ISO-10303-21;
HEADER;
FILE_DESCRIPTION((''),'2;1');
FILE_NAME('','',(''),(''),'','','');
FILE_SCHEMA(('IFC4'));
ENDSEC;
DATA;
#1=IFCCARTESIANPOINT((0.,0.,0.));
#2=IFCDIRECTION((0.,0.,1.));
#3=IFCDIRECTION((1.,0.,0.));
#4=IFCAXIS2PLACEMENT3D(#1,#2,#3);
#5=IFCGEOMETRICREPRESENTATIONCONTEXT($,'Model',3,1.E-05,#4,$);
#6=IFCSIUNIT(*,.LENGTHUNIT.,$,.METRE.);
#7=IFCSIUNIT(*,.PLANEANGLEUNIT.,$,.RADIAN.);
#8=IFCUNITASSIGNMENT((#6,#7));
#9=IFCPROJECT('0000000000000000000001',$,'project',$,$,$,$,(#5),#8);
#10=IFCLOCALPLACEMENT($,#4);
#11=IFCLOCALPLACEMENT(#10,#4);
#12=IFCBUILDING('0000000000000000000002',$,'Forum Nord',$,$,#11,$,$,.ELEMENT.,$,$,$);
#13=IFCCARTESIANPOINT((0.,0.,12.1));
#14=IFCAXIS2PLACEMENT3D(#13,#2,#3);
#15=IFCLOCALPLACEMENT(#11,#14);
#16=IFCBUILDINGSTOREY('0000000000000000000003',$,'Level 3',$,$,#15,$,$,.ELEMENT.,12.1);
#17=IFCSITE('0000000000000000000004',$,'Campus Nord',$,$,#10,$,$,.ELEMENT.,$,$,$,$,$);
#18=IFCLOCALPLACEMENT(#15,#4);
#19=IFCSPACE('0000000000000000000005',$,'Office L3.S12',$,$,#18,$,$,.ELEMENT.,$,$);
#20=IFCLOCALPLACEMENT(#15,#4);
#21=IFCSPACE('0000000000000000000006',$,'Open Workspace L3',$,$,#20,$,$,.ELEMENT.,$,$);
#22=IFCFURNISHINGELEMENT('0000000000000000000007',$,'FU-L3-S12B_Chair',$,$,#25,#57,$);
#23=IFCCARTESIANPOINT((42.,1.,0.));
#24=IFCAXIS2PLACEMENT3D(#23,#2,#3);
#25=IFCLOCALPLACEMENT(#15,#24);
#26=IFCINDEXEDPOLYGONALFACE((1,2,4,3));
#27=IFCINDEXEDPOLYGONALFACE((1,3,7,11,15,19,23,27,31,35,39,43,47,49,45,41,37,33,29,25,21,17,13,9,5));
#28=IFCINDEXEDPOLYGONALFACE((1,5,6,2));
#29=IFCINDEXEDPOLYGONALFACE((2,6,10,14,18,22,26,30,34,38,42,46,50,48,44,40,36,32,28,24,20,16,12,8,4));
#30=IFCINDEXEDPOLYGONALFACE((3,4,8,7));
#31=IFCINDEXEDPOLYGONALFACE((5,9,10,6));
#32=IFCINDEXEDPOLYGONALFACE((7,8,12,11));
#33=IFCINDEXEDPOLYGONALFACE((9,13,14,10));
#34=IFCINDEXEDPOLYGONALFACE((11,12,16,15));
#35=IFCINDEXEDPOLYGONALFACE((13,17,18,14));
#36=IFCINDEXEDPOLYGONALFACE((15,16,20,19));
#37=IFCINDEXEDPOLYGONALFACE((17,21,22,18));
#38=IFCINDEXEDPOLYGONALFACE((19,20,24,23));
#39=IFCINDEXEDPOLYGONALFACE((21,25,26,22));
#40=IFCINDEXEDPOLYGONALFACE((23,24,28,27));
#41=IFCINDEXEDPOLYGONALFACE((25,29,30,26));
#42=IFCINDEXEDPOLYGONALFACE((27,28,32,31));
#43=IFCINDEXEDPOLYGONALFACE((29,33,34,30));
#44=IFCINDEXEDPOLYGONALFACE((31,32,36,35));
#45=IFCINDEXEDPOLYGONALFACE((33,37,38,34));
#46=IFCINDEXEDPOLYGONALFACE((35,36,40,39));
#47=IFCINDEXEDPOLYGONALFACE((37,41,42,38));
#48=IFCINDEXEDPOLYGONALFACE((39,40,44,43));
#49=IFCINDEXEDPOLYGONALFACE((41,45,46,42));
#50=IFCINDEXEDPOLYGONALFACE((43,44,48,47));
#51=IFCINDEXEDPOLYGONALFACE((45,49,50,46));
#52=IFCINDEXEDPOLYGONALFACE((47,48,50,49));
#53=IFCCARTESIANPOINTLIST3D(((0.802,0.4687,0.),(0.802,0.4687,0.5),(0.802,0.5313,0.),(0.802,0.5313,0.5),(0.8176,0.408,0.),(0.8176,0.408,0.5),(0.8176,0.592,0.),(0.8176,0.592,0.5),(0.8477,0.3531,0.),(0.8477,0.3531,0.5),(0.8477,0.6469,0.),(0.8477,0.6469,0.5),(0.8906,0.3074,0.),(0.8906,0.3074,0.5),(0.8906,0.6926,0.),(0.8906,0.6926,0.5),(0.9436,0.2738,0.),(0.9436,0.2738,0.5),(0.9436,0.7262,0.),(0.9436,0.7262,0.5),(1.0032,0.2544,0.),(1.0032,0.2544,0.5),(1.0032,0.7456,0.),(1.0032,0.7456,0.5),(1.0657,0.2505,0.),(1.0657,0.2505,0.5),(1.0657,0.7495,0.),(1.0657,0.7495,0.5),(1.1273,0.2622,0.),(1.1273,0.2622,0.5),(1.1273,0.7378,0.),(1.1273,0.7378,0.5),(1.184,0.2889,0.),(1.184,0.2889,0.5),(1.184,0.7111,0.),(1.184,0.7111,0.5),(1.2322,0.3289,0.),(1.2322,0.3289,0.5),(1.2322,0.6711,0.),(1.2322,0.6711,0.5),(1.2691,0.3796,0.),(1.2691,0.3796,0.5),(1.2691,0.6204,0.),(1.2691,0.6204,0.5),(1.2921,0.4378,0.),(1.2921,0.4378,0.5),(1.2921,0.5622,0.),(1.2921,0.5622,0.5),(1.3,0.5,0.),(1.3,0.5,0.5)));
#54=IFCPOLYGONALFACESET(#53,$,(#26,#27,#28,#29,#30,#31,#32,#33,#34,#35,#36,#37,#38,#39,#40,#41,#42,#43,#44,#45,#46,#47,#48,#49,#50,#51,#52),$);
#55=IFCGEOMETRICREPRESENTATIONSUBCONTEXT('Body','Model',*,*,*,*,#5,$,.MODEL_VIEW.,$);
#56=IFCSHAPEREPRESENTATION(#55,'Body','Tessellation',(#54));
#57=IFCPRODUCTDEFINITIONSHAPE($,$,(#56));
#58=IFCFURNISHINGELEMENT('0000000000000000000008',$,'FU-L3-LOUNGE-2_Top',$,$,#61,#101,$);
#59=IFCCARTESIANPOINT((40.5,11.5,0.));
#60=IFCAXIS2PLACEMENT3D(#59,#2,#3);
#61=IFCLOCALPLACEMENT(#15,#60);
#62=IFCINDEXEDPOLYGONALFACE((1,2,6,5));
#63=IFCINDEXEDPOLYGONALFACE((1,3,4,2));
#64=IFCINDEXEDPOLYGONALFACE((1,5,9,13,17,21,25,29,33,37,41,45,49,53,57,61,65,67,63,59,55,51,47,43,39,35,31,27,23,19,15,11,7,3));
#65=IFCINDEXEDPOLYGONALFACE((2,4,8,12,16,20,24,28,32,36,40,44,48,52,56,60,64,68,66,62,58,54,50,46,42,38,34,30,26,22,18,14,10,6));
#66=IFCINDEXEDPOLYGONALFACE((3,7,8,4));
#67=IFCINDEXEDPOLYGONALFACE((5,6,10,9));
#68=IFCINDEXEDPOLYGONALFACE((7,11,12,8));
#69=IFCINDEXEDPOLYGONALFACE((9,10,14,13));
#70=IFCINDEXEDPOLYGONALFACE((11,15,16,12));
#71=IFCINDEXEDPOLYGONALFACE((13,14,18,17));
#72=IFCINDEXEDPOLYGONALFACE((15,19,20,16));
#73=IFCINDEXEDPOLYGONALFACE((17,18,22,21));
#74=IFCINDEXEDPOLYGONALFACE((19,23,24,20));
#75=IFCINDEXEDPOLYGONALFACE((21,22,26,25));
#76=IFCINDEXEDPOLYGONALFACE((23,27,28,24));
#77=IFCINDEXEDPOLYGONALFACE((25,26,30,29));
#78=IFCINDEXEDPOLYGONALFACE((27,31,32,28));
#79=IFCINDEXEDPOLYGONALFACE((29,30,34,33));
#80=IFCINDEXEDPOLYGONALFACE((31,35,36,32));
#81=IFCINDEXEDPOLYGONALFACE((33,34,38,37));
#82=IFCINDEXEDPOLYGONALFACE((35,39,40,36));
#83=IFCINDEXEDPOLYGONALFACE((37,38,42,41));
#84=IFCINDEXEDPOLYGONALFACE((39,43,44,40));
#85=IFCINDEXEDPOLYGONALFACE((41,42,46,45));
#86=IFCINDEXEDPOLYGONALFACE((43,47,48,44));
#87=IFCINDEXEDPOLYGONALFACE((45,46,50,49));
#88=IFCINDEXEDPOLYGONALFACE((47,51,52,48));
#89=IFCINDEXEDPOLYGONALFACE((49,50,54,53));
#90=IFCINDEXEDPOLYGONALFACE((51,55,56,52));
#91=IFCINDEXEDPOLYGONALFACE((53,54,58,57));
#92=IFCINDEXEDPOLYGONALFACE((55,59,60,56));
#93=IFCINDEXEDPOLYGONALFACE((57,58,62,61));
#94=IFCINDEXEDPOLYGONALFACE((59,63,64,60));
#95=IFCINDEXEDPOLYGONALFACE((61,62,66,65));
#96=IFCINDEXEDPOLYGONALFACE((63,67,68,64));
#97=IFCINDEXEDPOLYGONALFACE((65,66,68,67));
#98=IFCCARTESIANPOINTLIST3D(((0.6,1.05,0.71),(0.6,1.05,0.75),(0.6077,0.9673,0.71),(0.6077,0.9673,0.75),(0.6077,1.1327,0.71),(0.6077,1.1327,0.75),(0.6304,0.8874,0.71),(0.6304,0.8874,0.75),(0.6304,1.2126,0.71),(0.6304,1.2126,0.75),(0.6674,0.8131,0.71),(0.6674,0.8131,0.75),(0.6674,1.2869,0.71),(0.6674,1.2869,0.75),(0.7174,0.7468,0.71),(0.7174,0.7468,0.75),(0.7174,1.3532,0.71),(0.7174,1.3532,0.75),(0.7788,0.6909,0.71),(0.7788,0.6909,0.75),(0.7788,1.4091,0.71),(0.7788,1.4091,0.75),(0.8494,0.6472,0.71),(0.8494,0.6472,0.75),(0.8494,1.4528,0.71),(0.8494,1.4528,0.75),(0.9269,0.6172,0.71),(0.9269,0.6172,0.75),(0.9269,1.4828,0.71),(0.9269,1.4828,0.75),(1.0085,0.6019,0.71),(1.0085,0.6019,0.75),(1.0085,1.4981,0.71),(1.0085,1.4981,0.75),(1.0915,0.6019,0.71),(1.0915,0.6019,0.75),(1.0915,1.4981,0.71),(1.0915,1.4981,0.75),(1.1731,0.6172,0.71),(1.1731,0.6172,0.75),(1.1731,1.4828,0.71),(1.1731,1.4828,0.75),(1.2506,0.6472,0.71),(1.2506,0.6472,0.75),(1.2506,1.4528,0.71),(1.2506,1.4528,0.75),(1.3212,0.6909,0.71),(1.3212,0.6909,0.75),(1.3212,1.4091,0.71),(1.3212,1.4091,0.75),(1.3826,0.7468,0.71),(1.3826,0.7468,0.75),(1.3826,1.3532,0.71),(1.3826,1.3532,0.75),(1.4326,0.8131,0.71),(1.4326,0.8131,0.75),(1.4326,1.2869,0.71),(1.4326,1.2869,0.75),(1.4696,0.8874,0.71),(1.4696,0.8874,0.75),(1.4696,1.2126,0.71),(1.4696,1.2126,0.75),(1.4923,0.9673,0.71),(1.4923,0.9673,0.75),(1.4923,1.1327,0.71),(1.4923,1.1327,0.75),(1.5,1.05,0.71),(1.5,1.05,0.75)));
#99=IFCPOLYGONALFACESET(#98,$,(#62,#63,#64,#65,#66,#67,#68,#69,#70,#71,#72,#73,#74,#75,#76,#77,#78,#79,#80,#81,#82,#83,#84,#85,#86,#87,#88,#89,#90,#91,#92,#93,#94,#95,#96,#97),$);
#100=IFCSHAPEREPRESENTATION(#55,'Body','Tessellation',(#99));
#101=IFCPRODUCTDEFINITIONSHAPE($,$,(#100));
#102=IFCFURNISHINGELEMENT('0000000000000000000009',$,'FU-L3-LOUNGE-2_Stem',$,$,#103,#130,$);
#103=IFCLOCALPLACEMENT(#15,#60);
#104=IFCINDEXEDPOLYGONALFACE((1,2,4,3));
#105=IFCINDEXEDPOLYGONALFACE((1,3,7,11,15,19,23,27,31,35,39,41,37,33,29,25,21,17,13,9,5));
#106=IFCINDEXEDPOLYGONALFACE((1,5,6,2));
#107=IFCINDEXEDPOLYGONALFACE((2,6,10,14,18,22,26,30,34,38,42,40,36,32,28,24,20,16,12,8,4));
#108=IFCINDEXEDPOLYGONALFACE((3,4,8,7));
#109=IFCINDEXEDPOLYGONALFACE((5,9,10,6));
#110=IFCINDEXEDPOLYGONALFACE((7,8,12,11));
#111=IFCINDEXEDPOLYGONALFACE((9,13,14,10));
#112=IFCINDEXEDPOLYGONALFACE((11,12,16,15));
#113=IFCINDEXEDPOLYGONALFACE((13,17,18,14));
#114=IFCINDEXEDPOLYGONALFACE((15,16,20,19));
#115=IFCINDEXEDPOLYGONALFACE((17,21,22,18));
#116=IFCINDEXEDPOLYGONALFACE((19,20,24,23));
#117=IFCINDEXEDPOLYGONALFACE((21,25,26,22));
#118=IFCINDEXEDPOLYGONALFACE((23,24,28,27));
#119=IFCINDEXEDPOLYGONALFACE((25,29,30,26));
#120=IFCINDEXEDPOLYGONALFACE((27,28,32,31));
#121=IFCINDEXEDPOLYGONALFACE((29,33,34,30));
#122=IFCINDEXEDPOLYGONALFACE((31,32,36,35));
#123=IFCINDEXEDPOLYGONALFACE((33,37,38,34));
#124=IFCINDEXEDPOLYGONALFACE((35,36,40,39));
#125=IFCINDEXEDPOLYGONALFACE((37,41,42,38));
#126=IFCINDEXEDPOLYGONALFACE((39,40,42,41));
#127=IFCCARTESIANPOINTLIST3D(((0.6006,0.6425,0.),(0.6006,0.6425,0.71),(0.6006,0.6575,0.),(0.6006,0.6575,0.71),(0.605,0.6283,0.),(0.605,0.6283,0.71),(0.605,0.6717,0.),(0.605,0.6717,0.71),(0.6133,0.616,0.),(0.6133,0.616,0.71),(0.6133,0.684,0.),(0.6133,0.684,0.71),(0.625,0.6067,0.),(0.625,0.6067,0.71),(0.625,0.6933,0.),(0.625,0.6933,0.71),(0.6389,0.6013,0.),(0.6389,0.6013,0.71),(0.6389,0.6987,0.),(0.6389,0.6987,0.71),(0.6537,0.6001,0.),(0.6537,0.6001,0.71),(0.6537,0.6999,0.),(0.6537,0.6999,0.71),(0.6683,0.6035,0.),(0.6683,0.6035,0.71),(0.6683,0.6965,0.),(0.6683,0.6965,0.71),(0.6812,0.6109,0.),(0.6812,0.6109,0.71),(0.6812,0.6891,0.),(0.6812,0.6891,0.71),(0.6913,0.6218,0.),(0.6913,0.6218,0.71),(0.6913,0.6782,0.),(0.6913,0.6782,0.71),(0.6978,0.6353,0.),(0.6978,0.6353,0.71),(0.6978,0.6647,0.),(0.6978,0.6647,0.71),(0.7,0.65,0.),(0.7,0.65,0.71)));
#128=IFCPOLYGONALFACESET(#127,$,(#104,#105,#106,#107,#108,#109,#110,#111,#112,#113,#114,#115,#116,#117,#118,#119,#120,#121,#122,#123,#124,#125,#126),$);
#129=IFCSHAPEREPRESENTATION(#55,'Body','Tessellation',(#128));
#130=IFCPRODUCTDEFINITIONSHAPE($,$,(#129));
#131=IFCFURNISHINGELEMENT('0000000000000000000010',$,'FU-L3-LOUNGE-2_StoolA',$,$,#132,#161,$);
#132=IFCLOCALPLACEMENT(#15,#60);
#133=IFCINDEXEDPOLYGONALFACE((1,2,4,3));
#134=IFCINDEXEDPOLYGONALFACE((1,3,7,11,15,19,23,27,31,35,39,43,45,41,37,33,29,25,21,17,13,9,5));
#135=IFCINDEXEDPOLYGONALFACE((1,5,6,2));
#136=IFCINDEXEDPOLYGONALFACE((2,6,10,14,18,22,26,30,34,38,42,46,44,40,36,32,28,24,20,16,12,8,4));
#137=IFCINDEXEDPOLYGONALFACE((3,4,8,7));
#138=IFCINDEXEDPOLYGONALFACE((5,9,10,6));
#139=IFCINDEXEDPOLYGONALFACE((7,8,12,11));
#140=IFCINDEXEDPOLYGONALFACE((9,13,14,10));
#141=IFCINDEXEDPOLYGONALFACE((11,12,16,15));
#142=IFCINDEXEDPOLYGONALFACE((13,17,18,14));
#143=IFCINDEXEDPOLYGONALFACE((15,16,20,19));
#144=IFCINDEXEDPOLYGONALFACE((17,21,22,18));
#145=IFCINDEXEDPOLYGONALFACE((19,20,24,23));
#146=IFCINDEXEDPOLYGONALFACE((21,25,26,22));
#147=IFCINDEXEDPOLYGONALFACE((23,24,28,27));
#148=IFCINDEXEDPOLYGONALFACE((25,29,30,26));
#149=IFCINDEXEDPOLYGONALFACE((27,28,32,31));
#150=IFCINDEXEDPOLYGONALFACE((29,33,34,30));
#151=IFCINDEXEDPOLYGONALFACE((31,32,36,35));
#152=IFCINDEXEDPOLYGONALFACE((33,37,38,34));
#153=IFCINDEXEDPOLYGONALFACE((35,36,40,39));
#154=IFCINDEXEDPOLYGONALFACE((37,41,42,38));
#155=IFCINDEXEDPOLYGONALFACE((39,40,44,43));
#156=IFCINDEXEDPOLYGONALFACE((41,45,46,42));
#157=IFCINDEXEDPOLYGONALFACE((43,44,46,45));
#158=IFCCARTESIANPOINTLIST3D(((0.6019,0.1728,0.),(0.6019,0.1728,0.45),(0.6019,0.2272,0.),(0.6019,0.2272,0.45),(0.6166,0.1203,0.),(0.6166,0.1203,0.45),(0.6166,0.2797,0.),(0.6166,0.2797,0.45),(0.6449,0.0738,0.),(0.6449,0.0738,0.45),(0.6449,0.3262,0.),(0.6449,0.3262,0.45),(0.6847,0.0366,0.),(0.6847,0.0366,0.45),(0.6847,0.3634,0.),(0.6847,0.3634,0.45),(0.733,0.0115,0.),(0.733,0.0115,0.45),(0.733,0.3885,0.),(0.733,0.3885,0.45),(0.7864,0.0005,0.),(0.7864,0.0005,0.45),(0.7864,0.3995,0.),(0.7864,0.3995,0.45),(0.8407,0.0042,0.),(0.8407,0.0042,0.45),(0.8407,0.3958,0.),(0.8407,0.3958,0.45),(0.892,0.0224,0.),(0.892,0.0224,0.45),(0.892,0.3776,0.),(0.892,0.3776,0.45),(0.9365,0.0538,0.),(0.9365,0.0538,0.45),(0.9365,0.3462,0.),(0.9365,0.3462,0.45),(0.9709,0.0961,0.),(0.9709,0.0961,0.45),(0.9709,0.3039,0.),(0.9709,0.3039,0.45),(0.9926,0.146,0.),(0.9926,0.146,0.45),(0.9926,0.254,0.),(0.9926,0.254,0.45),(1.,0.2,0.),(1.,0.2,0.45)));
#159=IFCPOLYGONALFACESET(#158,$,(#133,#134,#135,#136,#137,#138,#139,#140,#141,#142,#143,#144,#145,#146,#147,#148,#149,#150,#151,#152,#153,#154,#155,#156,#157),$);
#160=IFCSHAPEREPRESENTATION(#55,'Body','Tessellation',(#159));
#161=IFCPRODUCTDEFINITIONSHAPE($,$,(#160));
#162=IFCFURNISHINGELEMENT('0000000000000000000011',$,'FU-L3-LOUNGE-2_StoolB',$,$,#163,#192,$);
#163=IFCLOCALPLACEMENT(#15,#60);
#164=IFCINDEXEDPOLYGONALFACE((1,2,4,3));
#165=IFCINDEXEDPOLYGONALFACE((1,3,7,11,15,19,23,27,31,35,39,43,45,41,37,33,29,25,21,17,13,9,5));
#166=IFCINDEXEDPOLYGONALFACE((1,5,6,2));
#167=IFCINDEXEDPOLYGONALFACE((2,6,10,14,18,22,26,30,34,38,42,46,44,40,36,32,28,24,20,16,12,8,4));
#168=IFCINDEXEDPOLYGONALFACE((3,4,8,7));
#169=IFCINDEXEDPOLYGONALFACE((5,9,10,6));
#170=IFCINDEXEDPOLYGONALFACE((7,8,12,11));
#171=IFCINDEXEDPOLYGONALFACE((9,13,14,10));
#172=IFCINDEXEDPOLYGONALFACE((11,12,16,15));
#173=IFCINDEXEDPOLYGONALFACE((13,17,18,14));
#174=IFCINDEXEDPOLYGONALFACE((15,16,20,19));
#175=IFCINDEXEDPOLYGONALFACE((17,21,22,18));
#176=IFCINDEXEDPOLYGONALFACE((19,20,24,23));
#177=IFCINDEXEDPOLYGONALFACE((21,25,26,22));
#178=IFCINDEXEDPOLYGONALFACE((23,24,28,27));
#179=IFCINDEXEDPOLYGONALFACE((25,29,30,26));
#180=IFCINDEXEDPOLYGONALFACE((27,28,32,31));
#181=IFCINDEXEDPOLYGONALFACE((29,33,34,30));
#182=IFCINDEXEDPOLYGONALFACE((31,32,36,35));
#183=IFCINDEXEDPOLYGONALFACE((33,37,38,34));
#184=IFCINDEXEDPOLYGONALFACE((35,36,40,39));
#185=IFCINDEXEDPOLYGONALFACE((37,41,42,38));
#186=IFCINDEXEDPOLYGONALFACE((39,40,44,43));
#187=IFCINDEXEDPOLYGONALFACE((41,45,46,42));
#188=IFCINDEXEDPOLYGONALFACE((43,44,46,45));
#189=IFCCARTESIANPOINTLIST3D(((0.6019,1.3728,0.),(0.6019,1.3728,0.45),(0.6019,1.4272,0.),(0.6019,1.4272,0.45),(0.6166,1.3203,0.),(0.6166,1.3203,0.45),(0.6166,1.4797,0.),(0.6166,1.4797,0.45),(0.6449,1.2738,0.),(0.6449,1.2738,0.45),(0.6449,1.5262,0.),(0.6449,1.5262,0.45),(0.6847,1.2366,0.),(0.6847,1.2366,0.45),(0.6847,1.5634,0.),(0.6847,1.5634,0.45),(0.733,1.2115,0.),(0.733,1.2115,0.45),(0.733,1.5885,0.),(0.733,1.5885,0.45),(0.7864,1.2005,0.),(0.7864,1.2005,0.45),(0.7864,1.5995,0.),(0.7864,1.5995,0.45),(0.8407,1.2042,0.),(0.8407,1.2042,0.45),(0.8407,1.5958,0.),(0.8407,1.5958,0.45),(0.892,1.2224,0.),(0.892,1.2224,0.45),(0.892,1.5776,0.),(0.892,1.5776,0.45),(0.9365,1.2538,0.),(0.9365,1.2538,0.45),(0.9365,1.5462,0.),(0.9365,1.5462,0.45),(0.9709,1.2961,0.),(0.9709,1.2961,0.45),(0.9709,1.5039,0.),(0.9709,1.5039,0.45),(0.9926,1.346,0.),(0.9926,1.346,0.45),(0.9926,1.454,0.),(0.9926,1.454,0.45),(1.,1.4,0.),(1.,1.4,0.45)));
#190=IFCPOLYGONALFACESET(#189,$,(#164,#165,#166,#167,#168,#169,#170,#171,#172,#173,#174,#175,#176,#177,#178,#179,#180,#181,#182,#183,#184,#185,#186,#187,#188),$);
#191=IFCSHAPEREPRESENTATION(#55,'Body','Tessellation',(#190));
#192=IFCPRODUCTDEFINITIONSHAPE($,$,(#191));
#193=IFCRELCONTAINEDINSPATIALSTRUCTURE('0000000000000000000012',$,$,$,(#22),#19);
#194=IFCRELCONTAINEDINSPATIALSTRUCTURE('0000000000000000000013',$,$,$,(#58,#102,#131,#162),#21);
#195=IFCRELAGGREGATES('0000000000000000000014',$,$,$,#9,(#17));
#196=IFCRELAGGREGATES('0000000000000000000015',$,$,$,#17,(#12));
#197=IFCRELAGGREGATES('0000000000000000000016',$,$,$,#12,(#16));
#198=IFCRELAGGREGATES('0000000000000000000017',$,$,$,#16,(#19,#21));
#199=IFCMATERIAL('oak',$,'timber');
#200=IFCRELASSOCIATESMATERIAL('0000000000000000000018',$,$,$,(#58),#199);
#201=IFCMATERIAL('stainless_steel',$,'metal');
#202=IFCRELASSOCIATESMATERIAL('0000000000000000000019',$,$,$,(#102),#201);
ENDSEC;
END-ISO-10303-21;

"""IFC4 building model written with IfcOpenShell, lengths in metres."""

from ifc_helpers import new_model, si_unit, frame, frame_2d, origin_with_axes, place, context, subcontext, project, spatial, circle, extrude, material, element, save


model = new_model("IFC4")

# Units and contexts
model_context = context("Model", 3, precision=1e-05, world=origin_with_axes())
body_context = subcontext(model_context, "Body", "Model", "MODEL_VIEW")
ifc_project = project(units=[si_unit("LENGTHUNIT", "METRE"), si_unit("PLANEANGLEUNIT", "RADIAN")], contexts=[model_context])

# Site, building, storey
site_placement = place(None, origin_with_axes())
site = spatial("IfcSite", under=ifc_project, at=site_placement, Name="Campus Nord", CompositionType="ELEMENT")
building_placement = place(site_placement, origin_with_axes())
building = spatial("IfcBuilding", under=site, at=building_placement, Name="Forum Nord", CompositionType="ELEMENT")
storey_placement = place(building_placement, frame((0.0, 0.0, 12.1), z_axis=(0.0, 0.0, 1.0), x_axis=(1.0, 0.0, 0.0)))
storey = spatial("IfcBuildingStorey", under=building, at=storey_placement, Name="Level 3", CompositionType="ELEMENT", Elevation=12.1)

# Shared definitions
space_1_placement = place(storey_placement, origin_with_axes())
space_1 = spatial("IfcSpace", under=storey, at=space_1_placement, Name="Office L3.S12", CompositionType="ELEMENT")

# Furnishing element
furnishing_1_placement = place(storey_placement, frame((42.0, 1.0, 0.0), z_axis=(0.0, 0.0, 1.0), x_axis=(1.0, 0.0, 0.0)))
element("IfcFurnishingElement", 1, at=furnishing_1_placement, inside=space_1, Name="FU-L3-S12B_Chair", context=body_context, shape_type="SweptSolid", body=[
    extrude(circle(Radius=0.25, at=frame_2d((1.05, 0.5), x_axis=(1.0, 0.0))), origin_with_axes(), (0.0, 0.0, 1.0), 0.5),
])

# Shared definitions
space_2_placement = place(storey_placement, origin_with_axes())
space_2 = spatial("IfcSpace", under=storey, at=space_2_placement, Name="Open Workspace L3", CompositionType="ELEMENT")

# Furnishing elements
ifc_material_1 = material(Name="oak", Category="timber")
furnishing_2_placement = place(storey_placement, frame((40.5, 11.5, 0.0), z_axis=(0.0, 0.0, 1.0), x_axis=(1.0, 0.0, 0.0)))
element("IfcFurnishingElement", 2, at=furnishing_2_placement, inside=space_2, material=ifc_material_1, Name="FU-L3-LOUNGE-2_Top", context=body_context, shape_type="SweptSolid", body=[
    extrude(circle(Radius=0.45, at=frame_2d((1.05, 1.05), x_axis=(1.0, 0.0))), frame((0.0, 0.0, 0.71), z_axis=(0.0, 0.0, 1.0), x_axis=(1.0, 0.0, 0.0)), (0.0, 0.0, 1.0), 0.04),
])
ifc_material_2 = material(Name="stainless_steel", Category="metal")
furnishing_3_placement = place(storey_placement, frame((40.5, 11.5, 0.0), z_axis=(0.0, 0.0, 1.0), x_axis=(1.0, 0.0, 0.0)))
element("IfcFurnishingElement", 3, at=furnishing_3_placement, inside=space_2, material=ifc_material_2, Name="FU-L3-LOUNGE-2_Stem", context=body_context, shape_type="SweptSolid", body=[
    extrude(circle(Radius=0.05, at=frame_2d((0.65, 0.65), x_axis=(1.0, 0.0))), origin_with_axes(), (0.0, 0.0, 1.0), 0.71),
])
furnishing_4_placement = place(storey_placement, frame((40.5, 11.5, 0.0), z_axis=(0.0, 0.0, 1.0), x_axis=(1.0, 0.0, 0.0)))
element("IfcFurnishingElement", 4, at=furnishing_4_placement, inside=space_2, Name="FU-L3-LOUNGE-2_StoolA", context=body_context, shape_type="SweptSolid", body=[
    extrude(circle(Radius=0.2, at=frame_2d((0.8, 0.2), x_axis=(1.0, 0.0))), origin_with_axes(), (0.0, 0.0, 1.0), 0.45),
])
furnishing_5_placement = place(storey_placement, frame((40.5, 11.5, 0.0), z_axis=(0.0, 0.0, 1.0), x_axis=(1.0, 0.0, 0.0)))
element("IfcFurnishingElement", 5, at=furnishing_5_placement, inside=space_2, Name="FU-L3-LOUNGE-2_StoolB", context=body_context, shape_type="SweptSolid", body=[
    extrude(circle(Radius=0.2, at=frame_2d((0.8, 1.4), x_axis=(1.0, 0.0))), origin_with_axes(), (0.0, 0.0, 1.0), 0.45),
])

save(model, "model.ifc")
